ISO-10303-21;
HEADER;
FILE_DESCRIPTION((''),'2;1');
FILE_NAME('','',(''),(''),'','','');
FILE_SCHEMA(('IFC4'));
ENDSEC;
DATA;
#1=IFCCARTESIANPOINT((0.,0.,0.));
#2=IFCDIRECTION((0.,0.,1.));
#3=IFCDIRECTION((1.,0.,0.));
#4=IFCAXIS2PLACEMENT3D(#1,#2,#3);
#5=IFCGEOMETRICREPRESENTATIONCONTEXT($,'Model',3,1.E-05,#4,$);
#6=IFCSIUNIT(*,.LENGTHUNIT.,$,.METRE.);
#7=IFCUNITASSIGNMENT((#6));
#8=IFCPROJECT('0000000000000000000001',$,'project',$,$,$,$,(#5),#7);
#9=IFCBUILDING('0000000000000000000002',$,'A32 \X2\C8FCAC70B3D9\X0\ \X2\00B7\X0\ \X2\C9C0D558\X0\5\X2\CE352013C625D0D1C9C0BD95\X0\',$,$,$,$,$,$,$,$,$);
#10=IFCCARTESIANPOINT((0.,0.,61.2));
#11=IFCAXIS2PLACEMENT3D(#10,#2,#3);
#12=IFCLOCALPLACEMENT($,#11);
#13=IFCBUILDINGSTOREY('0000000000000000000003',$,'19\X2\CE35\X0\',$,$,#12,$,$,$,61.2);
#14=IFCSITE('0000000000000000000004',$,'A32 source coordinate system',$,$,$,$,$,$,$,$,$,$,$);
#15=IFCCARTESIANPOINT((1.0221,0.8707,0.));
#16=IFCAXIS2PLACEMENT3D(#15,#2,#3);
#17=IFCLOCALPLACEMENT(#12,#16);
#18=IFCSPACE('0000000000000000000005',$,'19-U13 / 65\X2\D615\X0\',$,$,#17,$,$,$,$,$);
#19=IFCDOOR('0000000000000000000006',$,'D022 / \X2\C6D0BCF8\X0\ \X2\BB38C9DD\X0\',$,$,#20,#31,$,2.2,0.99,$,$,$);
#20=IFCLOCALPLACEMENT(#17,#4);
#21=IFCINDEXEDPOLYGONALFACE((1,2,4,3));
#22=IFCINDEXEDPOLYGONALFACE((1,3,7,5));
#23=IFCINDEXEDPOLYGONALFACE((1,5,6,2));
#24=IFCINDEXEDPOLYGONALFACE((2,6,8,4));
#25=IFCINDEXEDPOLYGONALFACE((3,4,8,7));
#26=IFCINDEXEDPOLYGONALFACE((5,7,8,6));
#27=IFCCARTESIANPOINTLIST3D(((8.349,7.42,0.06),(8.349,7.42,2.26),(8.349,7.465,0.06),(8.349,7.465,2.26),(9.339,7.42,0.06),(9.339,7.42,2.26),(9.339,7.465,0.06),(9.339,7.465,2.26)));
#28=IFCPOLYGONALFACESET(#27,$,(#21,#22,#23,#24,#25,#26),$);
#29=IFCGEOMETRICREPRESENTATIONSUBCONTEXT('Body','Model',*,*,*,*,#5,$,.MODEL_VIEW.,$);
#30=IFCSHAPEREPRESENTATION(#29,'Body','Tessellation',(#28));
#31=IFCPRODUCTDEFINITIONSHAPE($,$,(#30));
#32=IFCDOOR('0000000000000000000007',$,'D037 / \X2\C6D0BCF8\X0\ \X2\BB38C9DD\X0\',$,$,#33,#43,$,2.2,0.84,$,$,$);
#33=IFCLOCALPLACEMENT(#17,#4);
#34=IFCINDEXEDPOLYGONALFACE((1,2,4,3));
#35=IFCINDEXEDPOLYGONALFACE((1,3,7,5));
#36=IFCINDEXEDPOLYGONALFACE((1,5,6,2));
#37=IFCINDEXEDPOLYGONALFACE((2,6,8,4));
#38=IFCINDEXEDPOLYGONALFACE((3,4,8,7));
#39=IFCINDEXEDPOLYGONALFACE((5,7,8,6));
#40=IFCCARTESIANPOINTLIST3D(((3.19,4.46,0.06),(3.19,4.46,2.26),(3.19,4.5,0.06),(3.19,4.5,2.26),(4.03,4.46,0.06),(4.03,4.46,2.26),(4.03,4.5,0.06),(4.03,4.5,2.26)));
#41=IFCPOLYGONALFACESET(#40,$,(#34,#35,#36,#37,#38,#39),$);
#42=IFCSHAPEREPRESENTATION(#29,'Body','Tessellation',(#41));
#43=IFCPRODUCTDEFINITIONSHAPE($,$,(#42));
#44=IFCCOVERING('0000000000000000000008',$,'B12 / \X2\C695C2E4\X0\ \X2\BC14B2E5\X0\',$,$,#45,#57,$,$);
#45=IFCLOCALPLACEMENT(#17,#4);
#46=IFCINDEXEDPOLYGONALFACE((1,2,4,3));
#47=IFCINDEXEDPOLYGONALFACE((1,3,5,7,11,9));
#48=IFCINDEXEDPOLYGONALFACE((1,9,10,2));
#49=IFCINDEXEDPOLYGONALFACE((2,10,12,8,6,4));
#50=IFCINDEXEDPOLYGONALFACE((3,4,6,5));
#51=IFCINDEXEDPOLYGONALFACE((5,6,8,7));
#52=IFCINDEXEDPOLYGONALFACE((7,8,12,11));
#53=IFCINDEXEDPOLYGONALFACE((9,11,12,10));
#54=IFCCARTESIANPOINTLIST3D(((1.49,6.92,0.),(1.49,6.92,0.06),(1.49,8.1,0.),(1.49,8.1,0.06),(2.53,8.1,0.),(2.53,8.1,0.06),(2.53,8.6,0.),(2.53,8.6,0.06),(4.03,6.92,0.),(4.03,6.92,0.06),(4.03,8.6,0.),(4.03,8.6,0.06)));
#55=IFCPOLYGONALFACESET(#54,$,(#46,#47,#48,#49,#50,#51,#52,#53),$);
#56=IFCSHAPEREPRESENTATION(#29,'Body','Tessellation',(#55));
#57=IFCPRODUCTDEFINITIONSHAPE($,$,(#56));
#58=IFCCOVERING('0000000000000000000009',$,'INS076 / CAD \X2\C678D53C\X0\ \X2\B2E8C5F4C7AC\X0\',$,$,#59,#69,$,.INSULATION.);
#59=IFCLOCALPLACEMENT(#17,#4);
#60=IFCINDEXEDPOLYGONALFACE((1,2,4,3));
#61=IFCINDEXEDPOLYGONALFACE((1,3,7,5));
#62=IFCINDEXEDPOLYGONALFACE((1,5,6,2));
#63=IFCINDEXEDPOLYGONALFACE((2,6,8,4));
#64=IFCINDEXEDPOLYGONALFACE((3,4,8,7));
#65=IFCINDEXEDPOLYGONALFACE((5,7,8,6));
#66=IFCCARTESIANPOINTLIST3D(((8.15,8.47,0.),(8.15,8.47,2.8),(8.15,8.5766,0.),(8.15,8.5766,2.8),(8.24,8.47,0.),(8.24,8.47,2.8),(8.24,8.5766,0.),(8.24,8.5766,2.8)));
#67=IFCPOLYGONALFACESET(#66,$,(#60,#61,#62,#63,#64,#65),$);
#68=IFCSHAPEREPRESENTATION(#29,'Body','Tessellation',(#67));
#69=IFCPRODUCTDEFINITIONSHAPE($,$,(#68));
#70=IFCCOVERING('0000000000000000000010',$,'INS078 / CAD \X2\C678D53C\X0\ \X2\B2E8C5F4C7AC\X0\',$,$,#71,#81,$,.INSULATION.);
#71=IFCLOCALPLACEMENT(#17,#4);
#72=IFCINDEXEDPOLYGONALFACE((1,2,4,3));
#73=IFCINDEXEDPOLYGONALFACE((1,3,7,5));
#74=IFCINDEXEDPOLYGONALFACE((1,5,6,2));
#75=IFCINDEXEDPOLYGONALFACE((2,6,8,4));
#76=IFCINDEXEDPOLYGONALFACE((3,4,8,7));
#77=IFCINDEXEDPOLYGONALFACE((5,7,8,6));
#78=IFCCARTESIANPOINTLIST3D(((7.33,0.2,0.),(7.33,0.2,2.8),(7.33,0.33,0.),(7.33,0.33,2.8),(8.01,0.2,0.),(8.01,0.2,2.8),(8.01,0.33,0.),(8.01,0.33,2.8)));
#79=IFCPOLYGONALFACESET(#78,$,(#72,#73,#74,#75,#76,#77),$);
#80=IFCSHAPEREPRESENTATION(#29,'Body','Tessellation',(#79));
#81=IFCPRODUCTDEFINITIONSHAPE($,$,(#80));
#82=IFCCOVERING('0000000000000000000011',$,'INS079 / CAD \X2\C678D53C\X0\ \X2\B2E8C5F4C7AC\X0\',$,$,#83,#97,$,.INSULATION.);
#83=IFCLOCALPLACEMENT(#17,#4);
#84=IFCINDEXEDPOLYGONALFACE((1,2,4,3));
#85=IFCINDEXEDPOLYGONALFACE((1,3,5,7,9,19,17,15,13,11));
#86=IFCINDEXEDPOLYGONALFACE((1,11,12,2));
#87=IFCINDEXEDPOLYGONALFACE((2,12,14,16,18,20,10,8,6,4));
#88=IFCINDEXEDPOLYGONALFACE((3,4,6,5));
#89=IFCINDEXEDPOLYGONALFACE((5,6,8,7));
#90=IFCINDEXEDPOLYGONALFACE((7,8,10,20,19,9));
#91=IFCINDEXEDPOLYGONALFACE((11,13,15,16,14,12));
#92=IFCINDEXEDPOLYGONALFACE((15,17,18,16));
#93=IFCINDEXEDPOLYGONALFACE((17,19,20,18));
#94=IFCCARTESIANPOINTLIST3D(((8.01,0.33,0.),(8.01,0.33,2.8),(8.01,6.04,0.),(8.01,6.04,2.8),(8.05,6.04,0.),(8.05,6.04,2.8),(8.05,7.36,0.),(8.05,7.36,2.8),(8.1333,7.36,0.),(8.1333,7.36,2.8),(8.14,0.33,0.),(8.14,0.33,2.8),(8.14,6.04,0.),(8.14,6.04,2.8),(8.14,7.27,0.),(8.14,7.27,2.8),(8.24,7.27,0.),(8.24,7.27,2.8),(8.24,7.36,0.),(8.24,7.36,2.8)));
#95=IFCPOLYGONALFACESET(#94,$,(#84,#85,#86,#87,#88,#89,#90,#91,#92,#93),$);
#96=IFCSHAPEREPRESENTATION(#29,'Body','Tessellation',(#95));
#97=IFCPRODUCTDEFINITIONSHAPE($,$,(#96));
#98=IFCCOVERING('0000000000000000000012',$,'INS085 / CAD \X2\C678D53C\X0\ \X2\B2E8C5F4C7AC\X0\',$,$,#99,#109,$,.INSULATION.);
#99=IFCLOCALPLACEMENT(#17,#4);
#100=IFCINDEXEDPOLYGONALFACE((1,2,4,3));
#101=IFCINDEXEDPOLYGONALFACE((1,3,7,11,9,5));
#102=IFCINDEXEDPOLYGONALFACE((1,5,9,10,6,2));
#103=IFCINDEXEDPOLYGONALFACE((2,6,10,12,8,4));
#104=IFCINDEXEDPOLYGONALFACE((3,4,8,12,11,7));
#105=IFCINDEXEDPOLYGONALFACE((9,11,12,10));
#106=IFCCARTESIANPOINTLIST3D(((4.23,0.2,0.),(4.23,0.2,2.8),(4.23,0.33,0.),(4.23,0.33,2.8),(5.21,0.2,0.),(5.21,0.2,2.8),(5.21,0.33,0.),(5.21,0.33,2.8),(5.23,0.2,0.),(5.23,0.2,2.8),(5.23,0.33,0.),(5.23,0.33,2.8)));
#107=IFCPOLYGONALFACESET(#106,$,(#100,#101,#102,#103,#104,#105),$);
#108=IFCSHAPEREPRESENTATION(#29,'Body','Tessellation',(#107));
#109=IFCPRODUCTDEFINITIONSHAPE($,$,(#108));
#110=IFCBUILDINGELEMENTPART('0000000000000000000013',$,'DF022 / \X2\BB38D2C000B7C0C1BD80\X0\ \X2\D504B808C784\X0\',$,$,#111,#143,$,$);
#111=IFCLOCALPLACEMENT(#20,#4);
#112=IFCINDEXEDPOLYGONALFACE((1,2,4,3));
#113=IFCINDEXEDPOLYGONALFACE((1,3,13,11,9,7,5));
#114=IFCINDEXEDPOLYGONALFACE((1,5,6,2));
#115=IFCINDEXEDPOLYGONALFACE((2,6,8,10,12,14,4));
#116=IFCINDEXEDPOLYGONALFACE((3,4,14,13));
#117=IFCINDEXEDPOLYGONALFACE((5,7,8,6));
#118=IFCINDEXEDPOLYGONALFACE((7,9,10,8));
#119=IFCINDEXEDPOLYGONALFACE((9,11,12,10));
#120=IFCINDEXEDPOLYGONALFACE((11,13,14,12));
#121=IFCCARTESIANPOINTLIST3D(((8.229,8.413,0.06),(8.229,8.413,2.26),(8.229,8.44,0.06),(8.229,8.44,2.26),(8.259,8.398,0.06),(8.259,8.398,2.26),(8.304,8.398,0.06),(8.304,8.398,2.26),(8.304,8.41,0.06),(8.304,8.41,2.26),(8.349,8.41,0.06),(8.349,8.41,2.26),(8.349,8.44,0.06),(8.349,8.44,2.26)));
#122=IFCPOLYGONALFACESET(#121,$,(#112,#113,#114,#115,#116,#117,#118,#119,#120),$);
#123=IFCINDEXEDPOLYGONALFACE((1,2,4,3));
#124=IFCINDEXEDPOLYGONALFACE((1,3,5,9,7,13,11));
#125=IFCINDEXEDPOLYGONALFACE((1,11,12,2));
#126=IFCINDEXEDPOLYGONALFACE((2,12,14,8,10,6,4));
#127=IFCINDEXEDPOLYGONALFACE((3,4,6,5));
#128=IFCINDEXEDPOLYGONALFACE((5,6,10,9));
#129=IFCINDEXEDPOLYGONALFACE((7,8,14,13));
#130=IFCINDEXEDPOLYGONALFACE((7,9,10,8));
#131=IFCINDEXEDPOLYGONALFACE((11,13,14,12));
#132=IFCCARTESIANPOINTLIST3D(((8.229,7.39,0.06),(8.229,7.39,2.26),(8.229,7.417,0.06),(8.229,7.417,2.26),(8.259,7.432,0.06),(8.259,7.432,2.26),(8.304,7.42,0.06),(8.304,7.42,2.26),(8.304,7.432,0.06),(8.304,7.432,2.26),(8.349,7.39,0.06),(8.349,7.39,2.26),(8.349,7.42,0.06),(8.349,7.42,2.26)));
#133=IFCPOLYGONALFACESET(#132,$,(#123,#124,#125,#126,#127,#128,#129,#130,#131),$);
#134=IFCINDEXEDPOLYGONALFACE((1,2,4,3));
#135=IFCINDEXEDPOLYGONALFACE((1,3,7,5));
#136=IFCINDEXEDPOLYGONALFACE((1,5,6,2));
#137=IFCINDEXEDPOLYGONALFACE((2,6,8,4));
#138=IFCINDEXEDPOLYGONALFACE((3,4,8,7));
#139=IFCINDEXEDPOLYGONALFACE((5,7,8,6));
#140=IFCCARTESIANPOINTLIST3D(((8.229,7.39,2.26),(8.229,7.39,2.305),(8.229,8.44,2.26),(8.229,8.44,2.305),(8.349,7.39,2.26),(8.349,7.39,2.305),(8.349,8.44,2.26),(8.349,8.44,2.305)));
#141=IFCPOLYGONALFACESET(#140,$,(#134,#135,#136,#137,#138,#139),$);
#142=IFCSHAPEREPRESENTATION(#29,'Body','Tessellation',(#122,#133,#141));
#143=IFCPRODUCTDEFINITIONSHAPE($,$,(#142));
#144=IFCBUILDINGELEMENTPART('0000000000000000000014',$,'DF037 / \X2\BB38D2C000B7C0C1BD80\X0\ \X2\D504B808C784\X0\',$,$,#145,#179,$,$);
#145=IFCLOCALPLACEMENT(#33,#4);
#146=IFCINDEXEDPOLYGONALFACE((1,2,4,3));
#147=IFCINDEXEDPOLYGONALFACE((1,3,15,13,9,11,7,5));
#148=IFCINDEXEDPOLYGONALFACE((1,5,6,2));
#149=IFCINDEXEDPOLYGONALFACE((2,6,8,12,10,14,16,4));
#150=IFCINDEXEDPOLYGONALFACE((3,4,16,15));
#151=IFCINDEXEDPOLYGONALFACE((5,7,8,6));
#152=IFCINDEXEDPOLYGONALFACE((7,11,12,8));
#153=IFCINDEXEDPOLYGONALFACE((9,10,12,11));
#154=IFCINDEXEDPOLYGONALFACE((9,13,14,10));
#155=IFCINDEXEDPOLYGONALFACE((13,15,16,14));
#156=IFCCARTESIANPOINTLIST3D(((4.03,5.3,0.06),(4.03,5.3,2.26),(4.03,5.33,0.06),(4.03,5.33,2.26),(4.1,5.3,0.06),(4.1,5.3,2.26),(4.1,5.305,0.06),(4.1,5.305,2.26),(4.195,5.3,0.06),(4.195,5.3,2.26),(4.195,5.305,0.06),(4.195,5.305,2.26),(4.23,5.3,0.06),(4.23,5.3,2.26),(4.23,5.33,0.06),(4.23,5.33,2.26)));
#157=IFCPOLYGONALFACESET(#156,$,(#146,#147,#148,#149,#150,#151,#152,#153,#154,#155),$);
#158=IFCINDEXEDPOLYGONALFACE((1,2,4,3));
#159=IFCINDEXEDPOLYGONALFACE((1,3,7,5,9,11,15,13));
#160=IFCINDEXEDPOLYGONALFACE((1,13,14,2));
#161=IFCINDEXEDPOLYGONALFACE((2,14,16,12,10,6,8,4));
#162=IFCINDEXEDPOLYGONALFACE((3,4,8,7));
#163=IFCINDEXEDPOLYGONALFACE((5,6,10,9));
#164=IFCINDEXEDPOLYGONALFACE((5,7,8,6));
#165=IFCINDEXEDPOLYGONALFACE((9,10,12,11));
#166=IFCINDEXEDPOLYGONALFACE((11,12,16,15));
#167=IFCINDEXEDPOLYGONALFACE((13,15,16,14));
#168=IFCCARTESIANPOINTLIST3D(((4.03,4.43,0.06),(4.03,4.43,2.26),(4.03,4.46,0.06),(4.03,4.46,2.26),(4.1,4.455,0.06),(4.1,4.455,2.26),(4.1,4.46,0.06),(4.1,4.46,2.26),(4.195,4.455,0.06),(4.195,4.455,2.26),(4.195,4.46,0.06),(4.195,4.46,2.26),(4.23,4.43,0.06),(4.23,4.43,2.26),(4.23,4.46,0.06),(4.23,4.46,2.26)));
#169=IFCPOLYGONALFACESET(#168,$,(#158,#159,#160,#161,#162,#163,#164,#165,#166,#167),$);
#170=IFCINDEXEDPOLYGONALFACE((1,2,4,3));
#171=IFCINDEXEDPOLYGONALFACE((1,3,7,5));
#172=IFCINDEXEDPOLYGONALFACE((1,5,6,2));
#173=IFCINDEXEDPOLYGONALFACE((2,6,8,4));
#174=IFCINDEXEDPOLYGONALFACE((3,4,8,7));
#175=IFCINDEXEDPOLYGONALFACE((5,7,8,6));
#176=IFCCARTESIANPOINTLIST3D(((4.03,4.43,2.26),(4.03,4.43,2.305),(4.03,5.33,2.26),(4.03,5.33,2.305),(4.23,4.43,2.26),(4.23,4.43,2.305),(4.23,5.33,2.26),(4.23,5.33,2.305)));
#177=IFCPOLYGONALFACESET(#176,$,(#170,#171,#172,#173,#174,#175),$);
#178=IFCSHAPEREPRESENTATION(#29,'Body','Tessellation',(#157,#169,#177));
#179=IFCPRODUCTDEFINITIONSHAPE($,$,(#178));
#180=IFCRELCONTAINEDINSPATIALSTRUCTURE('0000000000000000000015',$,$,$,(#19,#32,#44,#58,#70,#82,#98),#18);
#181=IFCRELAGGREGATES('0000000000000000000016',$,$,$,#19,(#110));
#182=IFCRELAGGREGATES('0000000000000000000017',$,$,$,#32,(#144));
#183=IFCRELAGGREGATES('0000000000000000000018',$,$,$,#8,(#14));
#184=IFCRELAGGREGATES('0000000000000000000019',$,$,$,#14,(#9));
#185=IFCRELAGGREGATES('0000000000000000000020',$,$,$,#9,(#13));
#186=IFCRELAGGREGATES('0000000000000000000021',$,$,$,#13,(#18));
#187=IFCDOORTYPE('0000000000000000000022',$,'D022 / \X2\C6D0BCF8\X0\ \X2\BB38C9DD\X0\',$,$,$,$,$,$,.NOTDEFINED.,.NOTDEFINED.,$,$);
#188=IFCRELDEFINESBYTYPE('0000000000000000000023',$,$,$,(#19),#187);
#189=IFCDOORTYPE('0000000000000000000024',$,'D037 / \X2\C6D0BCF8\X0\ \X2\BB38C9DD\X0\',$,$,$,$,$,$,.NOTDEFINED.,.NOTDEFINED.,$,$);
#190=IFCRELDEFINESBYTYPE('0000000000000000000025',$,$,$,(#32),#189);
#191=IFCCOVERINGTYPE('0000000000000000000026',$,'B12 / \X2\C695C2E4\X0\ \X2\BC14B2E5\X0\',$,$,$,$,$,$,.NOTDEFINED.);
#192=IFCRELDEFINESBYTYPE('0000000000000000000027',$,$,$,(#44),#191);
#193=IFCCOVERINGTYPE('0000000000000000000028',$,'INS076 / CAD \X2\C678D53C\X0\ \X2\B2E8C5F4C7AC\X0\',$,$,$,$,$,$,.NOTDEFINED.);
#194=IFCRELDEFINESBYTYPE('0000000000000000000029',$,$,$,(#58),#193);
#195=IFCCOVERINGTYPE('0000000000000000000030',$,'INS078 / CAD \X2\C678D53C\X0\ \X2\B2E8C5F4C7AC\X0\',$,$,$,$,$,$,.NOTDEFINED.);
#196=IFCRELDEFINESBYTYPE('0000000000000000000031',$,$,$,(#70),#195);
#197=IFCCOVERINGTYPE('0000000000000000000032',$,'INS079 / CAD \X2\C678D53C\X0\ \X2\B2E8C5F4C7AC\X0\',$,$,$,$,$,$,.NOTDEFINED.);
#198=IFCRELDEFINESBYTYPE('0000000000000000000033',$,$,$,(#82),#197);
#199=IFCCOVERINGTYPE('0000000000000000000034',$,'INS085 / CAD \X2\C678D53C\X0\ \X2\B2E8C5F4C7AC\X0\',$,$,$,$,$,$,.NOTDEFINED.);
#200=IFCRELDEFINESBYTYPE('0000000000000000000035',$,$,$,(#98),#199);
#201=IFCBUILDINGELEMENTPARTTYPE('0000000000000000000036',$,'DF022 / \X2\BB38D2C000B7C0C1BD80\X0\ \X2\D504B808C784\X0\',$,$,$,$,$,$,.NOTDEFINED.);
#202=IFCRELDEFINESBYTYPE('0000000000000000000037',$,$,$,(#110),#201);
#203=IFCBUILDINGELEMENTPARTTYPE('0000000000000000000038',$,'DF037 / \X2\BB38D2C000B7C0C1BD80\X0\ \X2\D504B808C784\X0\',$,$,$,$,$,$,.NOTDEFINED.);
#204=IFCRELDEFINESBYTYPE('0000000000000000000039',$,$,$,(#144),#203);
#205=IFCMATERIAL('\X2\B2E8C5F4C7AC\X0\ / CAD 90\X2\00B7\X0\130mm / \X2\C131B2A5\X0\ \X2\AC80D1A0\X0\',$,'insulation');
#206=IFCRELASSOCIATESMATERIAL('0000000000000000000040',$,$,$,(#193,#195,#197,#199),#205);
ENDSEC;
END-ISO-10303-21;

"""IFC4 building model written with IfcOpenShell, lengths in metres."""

from ifc_helpers import new_model, si_unit, frame, origin, origin_with_axes, place, context, subcontext, project, spatial, polyline, outline, extrude, source, transform, mapped, material, type_object, type_shapes, element, aggregate, save


model = new_model("IFC4")

# Units and contexts
model_context = context("Model", 3, precision=1e-05, world=origin_with_axes())
body_context = subcontext(model_context, "Body", "Model", "MODEL_VIEW")
ifc_project = project(units=[si_unit("LENGTHUNIT", "METRE")], contexts=[model_context])

# Site, building, storey
site = spatial("IfcSite", under=ifc_project, Name="A32 source coordinate system")
building = spatial("IfcBuilding", under=site, Name="A32 주거동 · 지하5층–옥탑지붕")
storey_placement = place(None, frame((0.0, 0.0, 61.2), z_axis=(0.0, 0.0, 1.0), x_axis=(1.0, 0.0, 0.0)))
storey = spatial("IfcBuildingStorey", under=building, at=storey_placement, Name="19층", Elevation=61.2)

# Shared definitions
space_placement = place(storey_placement, frame((1.0221, 0.8707, 0.0), z_axis=(0.0, 0.0, 1.0), x_axis=(1.0, 0.0, 0.0)))
space = spatial("IfcSpace", under=storey, at=space_placement, Name="19-U13 / 65형")

# Doors
door_type_1 = type_object("IfcDoorType", Name="D022 / 원본 문짝", OperationType="NOTDEFINED", PredefinedType="NOTDEFINED")
shared_shape_1 = source(origin(), body_context, "Body", "SweptSolid", [
    extrude(outline(polyline([(9.339, 7.465), (9.339, 7.42), (8.349, 7.42), (8.349, 7.465), (9.339, 7.465)])), frame((0.0, 0.0, 0.06)), (0.0, 0.0, 1.0), 2.2),
])
type_shapes(door_type_1, [shared_shape_1])
door_1_placement = place(space_placement, origin_with_axes())
door_1 = element("IfcDoor", 1, at=door_1_placement, inside=space, type_object=door_type_1, Name="D022 / 원본 문짝", OverallHeight=2.2, OverallWidth=0.99, context=body_context, shape_type="MappedRepresentation", body=[
    mapped(shared_shape_1, transform((0.0, 0.0, 0.0), scale=1.0)),
])
door_type_2 = type_object("IfcDoorType", Name="D037 / 원본 문짝", OperationType="NOTDEFINED", PredefinedType="NOTDEFINED")
shared_shape_2 = source(origin(), body_context, "Body", "SweptSolid", [
    extrude(outline(polyline([(4.03, 4.46), (3.19, 4.46), (3.19, 4.5), (4.03, 4.5), (4.03, 4.46)])), frame((0.0, 0.0, 0.06)), (0.0, 0.0, 1.0), 2.2),
])
type_shapes(door_type_2, [shared_shape_2])
door_2_placement = place(space_placement, origin_with_axes())
door_2 = element("IfcDoor", 2, at=door_2_placement, inside=space, type_object=door_type_2, Name="D037 / 원본 문짝", OverallHeight=2.2, OverallWidth=0.84, context=body_context, shape_type="MappedRepresentation", body=[
    mapped(shared_shape_2, transform((0.0, 0.0, 0.0), scale=1.0)),
])

# Coverings
covering_type_1 = type_object("IfcCoveringType", Name="B12 / 욕실 바닥", PredefinedType="NOTDEFINED")
shared_shape_3 = source(origin(), body_context, "Body", "SweptSolid", [
    extrude(outline(polyline([(2.53, 8.6), (4.03, 8.6), (4.03, 6.92), (1.49, 6.92), (1.49, 8.1), (2.53, 8.1), (2.53, 8.6)])), origin(), (0.0, 0.0, 1.0), 0.06),
])
type_shapes(covering_type_1, [shared_shape_3])
covering_1_placement = place(space_placement, origin_with_axes())
element("IfcCovering", 3, at=covering_1_placement, inside=space, type_object=covering_type_1, Name="B12 / 욕실 바닥", context=body_context, shape_type="MappedRepresentation", body=[
    mapped(shared_shape_3, transform((0.0, 0.0, 0.0), scale=1.0)),
])
ifc_material = material(Name="단열재 / CAD 90·130mm / 성능 검토", Category="insulation")
covering_type_2 = type_object("IfcCoveringType", Name="INS076 / CAD 외피 단열재", PredefinedType="NOTDEFINED", material=ifc_material)
shared_shape_4 = source(origin(), body_context, "Body", "SweptSolid", [
    extrude(outline(polyline([(8.24, 8.5766), (8.24, 8.47), (8.15, 8.47), (8.15, 8.5766), (8.24, 8.5766)])), origin(), (0.0, 0.0, 1.0), 2.8),
])
type_shapes(covering_type_2, [shared_shape_4])
covering_2_placement = place(space_placement, origin_with_axes())
element("IfcCovering", 4, at=covering_2_placement, inside=space, type_object=covering_type_2, Name="INS076 / CAD 외피 단열재", PredefinedType="INSULATION", context=body_context, shape_type="MappedRepresentation", body=[
    mapped(shared_shape_4, transform((0.0, 0.0, 0.0), scale=1.0)),
])
covering_type_3 = type_object("IfcCoveringType", Name="INS078 / CAD 외피 단열재", PredefinedType="NOTDEFINED", material=ifc_material)
shared_shape_5 = source(origin(), body_context, "Body", "SweptSolid", [
    extrude(outline(polyline([(8.01, 0.2), (7.33, 0.2), (7.33, 0.33), (8.01, 0.33), (8.01, 0.2)])), origin(), (0.0, 0.0, 1.0), 2.8),
])
type_shapes(covering_type_3, [shared_shape_5])
covering_3_placement = place(space_placement, origin_with_axes())
element("IfcCovering", 5, at=covering_3_placement, inside=space, type_object=covering_type_3, Name="INS078 / CAD 외피 단열재", PredefinedType="INSULATION", context=body_context, shape_type="MappedRepresentation", body=[
    mapped(shared_shape_5, transform((0.0, 0.0, 0.0), scale=1.0)),
])
covering_type_4 = type_object("IfcCoveringType", Name="INS079 / CAD 외피 단열재", PredefinedType="NOTDEFINED", material=ifc_material)
shared_shape_6 = source(origin(), body_context, "Body", "SweptSolid", [
    extrude(outline(polyline([(8.24, 7.27), (8.14, 7.27), (8.14, 6.04), (8.14, 0.33), (8.01, 0.33), (8.01, 6.04), (8.05, 6.04), (8.05, 7.36), (8.1333, 7.36), (8.24, 7.36), (8.24, 7.27)])), origin(), (0.0, 0.0, 1.0), 2.8),
])
type_shapes(covering_type_4, [shared_shape_6])
covering_4_placement = place(space_placement, origin_with_axes())
element("IfcCovering", 6, at=covering_4_placement, inside=space, type_object=covering_type_4, Name="INS079 / CAD 외피 단열재", PredefinedType="INSULATION", context=body_context, shape_type="MappedRepresentation", body=[
    mapped(shared_shape_6, transform((0.0, 0.0, 0.0), scale=1.0)),
])
covering_type_5 = type_object("IfcCoveringType", Name="INS085 / CAD 외피 단열재", PredefinedType="NOTDEFINED", material=ifc_material)
shared_shape_7 = source(origin(), body_context, "Body", "SweptSolid", [
    extrude(outline(polyline([(4.23, 0.2), (4.23, 0.33), (5.21, 0.33), (5.23, 0.33), (5.23, 0.2), (5.21, 0.2), (4.23, 0.2)])), origin(), (0.0, 0.0, 1.0), 2.8),
])
type_shapes(covering_type_5, [shared_shape_7])
covering_5_placement = place(space_placement, origin_with_axes())
element("IfcCovering", 7, at=covering_5_placement, inside=space, type_object=covering_type_5, Name="INS085 / CAD 외피 단열재", PredefinedType="INSULATION", context=body_context, shape_type="MappedRepresentation", body=[
    mapped(shared_shape_7, transform((0.0, 0.0, 0.0), scale=1.0)),
])

# Building element parts
building_element_part_type_1 = type_object("IfcBuildingElementPartType", Name="DF022 / 문틀·상부 프레임", PredefinedType="NOTDEFINED")
shared_shape_8 = source(origin(), body_context, "Body", "SweptSolid", [
    extrude(outline(polyline([(8.349, 8.41), (8.304, 8.41), (8.304, 8.398), (8.259, 8.398), (8.229, 8.413), (8.229, 8.44), (8.349, 8.44), (8.349, 8.41)])), frame((0.0, 0.0, 0.06)), (0.0, 0.0, 1.0), 2.2),
    extrude(outline(polyline([(8.229, 7.39), (8.229, 7.417), (8.259, 7.432), (8.304, 7.432), (8.304, 7.42), (8.349, 7.42), (8.349, 7.39), (8.229, 7.39)])), frame((0.0, 0.0, 0.06)), (0.0, 0.0, 1.0), 2.2),
    extrude(outline(polyline([(8.229, 7.39), (8.229, 8.44), (8.349, 8.44), (8.349, 7.39), (8.229, 7.39)])), frame((0.0, 0.0, 2.26)), (0.0, 0.0, 1.0), 0.045),
])
type_shapes(building_element_part_type_1, [shared_shape_8])
building_element_part_1_placement = place(door_1_placement, origin_with_axes())
building_element_part_1 = element("IfcBuildingElementPart", 8, at=building_element_part_1_placement, type_object=building_element_part_type_1, Name="DF022 / 문틀·상부 프레임", context=body_context, shape_type="MappedRepresentation", body=[
    mapped(shared_shape_8, transform((0.0, 0.0, 0.0), scale=1.0)),
])
aggregate(door_1, [building_element_part_1])
building_element_part_type_2 = type_object("IfcBuildingElementPartType", Name="DF037 / 문틀·상부 프레임", PredefinedType="NOTDEFINED")
shared_shape_9 = source(origin(), body_context, "Body", "SweptSolid", [
    extrude(outline(polyline([(4.23, 5.33), (4.23, 5.3), (4.195, 5.3), (4.195, 5.305), (4.1, 5.305), (4.1, 5.3), (4.03, 5.3), (4.03, 5.33), (4.23, 5.33)])), frame((0.0, 0.0, 0.06)), (0.0, 0.0, 1.0), 2.2),
    extrude(outline(polyline([(4.03, 4.46), (4.1, 4.46), (4.1, 4.455), (4.195, 4.455), (4.195, 4.46), (4.23, 4.46), (4.23, 4.43), (4.03, 4.43), (4.03, 4.46)])), frame((0.0, 0.0, 0.06)), (0.0, 0.0, 1.0), 2.2),
    extrude(outline(polyline([(4.03, 4.43), (4.03, 5.33), (4.23, 5.33), (4.23, 4.43), (4.03, 4.43)])), frame((0.0, 0.0, 2.26)), (0.0, 0.0, 1.0), 0.045),
])
type_shapes(building_element_part_type_2, [shared_shape_9])
building_element_part_2_placement = place(door_2_placement, origin_with_axes())
building_element_part_2 = element("IfcBuildingElementPart", 9, at=building_element_part_2_placement, type_object=building_element_part_type_2, Name="DF037 / 문틀·상부 프레임", context=body_context, shape_type="MappedRepresentation", body=[
    mapped(shared_shape_9, transform((0.0, 0.0, 0.0), scale=1.0)),
])
aggregate(door_2, [building_element_part_2])

save(model, "model.ifc")
